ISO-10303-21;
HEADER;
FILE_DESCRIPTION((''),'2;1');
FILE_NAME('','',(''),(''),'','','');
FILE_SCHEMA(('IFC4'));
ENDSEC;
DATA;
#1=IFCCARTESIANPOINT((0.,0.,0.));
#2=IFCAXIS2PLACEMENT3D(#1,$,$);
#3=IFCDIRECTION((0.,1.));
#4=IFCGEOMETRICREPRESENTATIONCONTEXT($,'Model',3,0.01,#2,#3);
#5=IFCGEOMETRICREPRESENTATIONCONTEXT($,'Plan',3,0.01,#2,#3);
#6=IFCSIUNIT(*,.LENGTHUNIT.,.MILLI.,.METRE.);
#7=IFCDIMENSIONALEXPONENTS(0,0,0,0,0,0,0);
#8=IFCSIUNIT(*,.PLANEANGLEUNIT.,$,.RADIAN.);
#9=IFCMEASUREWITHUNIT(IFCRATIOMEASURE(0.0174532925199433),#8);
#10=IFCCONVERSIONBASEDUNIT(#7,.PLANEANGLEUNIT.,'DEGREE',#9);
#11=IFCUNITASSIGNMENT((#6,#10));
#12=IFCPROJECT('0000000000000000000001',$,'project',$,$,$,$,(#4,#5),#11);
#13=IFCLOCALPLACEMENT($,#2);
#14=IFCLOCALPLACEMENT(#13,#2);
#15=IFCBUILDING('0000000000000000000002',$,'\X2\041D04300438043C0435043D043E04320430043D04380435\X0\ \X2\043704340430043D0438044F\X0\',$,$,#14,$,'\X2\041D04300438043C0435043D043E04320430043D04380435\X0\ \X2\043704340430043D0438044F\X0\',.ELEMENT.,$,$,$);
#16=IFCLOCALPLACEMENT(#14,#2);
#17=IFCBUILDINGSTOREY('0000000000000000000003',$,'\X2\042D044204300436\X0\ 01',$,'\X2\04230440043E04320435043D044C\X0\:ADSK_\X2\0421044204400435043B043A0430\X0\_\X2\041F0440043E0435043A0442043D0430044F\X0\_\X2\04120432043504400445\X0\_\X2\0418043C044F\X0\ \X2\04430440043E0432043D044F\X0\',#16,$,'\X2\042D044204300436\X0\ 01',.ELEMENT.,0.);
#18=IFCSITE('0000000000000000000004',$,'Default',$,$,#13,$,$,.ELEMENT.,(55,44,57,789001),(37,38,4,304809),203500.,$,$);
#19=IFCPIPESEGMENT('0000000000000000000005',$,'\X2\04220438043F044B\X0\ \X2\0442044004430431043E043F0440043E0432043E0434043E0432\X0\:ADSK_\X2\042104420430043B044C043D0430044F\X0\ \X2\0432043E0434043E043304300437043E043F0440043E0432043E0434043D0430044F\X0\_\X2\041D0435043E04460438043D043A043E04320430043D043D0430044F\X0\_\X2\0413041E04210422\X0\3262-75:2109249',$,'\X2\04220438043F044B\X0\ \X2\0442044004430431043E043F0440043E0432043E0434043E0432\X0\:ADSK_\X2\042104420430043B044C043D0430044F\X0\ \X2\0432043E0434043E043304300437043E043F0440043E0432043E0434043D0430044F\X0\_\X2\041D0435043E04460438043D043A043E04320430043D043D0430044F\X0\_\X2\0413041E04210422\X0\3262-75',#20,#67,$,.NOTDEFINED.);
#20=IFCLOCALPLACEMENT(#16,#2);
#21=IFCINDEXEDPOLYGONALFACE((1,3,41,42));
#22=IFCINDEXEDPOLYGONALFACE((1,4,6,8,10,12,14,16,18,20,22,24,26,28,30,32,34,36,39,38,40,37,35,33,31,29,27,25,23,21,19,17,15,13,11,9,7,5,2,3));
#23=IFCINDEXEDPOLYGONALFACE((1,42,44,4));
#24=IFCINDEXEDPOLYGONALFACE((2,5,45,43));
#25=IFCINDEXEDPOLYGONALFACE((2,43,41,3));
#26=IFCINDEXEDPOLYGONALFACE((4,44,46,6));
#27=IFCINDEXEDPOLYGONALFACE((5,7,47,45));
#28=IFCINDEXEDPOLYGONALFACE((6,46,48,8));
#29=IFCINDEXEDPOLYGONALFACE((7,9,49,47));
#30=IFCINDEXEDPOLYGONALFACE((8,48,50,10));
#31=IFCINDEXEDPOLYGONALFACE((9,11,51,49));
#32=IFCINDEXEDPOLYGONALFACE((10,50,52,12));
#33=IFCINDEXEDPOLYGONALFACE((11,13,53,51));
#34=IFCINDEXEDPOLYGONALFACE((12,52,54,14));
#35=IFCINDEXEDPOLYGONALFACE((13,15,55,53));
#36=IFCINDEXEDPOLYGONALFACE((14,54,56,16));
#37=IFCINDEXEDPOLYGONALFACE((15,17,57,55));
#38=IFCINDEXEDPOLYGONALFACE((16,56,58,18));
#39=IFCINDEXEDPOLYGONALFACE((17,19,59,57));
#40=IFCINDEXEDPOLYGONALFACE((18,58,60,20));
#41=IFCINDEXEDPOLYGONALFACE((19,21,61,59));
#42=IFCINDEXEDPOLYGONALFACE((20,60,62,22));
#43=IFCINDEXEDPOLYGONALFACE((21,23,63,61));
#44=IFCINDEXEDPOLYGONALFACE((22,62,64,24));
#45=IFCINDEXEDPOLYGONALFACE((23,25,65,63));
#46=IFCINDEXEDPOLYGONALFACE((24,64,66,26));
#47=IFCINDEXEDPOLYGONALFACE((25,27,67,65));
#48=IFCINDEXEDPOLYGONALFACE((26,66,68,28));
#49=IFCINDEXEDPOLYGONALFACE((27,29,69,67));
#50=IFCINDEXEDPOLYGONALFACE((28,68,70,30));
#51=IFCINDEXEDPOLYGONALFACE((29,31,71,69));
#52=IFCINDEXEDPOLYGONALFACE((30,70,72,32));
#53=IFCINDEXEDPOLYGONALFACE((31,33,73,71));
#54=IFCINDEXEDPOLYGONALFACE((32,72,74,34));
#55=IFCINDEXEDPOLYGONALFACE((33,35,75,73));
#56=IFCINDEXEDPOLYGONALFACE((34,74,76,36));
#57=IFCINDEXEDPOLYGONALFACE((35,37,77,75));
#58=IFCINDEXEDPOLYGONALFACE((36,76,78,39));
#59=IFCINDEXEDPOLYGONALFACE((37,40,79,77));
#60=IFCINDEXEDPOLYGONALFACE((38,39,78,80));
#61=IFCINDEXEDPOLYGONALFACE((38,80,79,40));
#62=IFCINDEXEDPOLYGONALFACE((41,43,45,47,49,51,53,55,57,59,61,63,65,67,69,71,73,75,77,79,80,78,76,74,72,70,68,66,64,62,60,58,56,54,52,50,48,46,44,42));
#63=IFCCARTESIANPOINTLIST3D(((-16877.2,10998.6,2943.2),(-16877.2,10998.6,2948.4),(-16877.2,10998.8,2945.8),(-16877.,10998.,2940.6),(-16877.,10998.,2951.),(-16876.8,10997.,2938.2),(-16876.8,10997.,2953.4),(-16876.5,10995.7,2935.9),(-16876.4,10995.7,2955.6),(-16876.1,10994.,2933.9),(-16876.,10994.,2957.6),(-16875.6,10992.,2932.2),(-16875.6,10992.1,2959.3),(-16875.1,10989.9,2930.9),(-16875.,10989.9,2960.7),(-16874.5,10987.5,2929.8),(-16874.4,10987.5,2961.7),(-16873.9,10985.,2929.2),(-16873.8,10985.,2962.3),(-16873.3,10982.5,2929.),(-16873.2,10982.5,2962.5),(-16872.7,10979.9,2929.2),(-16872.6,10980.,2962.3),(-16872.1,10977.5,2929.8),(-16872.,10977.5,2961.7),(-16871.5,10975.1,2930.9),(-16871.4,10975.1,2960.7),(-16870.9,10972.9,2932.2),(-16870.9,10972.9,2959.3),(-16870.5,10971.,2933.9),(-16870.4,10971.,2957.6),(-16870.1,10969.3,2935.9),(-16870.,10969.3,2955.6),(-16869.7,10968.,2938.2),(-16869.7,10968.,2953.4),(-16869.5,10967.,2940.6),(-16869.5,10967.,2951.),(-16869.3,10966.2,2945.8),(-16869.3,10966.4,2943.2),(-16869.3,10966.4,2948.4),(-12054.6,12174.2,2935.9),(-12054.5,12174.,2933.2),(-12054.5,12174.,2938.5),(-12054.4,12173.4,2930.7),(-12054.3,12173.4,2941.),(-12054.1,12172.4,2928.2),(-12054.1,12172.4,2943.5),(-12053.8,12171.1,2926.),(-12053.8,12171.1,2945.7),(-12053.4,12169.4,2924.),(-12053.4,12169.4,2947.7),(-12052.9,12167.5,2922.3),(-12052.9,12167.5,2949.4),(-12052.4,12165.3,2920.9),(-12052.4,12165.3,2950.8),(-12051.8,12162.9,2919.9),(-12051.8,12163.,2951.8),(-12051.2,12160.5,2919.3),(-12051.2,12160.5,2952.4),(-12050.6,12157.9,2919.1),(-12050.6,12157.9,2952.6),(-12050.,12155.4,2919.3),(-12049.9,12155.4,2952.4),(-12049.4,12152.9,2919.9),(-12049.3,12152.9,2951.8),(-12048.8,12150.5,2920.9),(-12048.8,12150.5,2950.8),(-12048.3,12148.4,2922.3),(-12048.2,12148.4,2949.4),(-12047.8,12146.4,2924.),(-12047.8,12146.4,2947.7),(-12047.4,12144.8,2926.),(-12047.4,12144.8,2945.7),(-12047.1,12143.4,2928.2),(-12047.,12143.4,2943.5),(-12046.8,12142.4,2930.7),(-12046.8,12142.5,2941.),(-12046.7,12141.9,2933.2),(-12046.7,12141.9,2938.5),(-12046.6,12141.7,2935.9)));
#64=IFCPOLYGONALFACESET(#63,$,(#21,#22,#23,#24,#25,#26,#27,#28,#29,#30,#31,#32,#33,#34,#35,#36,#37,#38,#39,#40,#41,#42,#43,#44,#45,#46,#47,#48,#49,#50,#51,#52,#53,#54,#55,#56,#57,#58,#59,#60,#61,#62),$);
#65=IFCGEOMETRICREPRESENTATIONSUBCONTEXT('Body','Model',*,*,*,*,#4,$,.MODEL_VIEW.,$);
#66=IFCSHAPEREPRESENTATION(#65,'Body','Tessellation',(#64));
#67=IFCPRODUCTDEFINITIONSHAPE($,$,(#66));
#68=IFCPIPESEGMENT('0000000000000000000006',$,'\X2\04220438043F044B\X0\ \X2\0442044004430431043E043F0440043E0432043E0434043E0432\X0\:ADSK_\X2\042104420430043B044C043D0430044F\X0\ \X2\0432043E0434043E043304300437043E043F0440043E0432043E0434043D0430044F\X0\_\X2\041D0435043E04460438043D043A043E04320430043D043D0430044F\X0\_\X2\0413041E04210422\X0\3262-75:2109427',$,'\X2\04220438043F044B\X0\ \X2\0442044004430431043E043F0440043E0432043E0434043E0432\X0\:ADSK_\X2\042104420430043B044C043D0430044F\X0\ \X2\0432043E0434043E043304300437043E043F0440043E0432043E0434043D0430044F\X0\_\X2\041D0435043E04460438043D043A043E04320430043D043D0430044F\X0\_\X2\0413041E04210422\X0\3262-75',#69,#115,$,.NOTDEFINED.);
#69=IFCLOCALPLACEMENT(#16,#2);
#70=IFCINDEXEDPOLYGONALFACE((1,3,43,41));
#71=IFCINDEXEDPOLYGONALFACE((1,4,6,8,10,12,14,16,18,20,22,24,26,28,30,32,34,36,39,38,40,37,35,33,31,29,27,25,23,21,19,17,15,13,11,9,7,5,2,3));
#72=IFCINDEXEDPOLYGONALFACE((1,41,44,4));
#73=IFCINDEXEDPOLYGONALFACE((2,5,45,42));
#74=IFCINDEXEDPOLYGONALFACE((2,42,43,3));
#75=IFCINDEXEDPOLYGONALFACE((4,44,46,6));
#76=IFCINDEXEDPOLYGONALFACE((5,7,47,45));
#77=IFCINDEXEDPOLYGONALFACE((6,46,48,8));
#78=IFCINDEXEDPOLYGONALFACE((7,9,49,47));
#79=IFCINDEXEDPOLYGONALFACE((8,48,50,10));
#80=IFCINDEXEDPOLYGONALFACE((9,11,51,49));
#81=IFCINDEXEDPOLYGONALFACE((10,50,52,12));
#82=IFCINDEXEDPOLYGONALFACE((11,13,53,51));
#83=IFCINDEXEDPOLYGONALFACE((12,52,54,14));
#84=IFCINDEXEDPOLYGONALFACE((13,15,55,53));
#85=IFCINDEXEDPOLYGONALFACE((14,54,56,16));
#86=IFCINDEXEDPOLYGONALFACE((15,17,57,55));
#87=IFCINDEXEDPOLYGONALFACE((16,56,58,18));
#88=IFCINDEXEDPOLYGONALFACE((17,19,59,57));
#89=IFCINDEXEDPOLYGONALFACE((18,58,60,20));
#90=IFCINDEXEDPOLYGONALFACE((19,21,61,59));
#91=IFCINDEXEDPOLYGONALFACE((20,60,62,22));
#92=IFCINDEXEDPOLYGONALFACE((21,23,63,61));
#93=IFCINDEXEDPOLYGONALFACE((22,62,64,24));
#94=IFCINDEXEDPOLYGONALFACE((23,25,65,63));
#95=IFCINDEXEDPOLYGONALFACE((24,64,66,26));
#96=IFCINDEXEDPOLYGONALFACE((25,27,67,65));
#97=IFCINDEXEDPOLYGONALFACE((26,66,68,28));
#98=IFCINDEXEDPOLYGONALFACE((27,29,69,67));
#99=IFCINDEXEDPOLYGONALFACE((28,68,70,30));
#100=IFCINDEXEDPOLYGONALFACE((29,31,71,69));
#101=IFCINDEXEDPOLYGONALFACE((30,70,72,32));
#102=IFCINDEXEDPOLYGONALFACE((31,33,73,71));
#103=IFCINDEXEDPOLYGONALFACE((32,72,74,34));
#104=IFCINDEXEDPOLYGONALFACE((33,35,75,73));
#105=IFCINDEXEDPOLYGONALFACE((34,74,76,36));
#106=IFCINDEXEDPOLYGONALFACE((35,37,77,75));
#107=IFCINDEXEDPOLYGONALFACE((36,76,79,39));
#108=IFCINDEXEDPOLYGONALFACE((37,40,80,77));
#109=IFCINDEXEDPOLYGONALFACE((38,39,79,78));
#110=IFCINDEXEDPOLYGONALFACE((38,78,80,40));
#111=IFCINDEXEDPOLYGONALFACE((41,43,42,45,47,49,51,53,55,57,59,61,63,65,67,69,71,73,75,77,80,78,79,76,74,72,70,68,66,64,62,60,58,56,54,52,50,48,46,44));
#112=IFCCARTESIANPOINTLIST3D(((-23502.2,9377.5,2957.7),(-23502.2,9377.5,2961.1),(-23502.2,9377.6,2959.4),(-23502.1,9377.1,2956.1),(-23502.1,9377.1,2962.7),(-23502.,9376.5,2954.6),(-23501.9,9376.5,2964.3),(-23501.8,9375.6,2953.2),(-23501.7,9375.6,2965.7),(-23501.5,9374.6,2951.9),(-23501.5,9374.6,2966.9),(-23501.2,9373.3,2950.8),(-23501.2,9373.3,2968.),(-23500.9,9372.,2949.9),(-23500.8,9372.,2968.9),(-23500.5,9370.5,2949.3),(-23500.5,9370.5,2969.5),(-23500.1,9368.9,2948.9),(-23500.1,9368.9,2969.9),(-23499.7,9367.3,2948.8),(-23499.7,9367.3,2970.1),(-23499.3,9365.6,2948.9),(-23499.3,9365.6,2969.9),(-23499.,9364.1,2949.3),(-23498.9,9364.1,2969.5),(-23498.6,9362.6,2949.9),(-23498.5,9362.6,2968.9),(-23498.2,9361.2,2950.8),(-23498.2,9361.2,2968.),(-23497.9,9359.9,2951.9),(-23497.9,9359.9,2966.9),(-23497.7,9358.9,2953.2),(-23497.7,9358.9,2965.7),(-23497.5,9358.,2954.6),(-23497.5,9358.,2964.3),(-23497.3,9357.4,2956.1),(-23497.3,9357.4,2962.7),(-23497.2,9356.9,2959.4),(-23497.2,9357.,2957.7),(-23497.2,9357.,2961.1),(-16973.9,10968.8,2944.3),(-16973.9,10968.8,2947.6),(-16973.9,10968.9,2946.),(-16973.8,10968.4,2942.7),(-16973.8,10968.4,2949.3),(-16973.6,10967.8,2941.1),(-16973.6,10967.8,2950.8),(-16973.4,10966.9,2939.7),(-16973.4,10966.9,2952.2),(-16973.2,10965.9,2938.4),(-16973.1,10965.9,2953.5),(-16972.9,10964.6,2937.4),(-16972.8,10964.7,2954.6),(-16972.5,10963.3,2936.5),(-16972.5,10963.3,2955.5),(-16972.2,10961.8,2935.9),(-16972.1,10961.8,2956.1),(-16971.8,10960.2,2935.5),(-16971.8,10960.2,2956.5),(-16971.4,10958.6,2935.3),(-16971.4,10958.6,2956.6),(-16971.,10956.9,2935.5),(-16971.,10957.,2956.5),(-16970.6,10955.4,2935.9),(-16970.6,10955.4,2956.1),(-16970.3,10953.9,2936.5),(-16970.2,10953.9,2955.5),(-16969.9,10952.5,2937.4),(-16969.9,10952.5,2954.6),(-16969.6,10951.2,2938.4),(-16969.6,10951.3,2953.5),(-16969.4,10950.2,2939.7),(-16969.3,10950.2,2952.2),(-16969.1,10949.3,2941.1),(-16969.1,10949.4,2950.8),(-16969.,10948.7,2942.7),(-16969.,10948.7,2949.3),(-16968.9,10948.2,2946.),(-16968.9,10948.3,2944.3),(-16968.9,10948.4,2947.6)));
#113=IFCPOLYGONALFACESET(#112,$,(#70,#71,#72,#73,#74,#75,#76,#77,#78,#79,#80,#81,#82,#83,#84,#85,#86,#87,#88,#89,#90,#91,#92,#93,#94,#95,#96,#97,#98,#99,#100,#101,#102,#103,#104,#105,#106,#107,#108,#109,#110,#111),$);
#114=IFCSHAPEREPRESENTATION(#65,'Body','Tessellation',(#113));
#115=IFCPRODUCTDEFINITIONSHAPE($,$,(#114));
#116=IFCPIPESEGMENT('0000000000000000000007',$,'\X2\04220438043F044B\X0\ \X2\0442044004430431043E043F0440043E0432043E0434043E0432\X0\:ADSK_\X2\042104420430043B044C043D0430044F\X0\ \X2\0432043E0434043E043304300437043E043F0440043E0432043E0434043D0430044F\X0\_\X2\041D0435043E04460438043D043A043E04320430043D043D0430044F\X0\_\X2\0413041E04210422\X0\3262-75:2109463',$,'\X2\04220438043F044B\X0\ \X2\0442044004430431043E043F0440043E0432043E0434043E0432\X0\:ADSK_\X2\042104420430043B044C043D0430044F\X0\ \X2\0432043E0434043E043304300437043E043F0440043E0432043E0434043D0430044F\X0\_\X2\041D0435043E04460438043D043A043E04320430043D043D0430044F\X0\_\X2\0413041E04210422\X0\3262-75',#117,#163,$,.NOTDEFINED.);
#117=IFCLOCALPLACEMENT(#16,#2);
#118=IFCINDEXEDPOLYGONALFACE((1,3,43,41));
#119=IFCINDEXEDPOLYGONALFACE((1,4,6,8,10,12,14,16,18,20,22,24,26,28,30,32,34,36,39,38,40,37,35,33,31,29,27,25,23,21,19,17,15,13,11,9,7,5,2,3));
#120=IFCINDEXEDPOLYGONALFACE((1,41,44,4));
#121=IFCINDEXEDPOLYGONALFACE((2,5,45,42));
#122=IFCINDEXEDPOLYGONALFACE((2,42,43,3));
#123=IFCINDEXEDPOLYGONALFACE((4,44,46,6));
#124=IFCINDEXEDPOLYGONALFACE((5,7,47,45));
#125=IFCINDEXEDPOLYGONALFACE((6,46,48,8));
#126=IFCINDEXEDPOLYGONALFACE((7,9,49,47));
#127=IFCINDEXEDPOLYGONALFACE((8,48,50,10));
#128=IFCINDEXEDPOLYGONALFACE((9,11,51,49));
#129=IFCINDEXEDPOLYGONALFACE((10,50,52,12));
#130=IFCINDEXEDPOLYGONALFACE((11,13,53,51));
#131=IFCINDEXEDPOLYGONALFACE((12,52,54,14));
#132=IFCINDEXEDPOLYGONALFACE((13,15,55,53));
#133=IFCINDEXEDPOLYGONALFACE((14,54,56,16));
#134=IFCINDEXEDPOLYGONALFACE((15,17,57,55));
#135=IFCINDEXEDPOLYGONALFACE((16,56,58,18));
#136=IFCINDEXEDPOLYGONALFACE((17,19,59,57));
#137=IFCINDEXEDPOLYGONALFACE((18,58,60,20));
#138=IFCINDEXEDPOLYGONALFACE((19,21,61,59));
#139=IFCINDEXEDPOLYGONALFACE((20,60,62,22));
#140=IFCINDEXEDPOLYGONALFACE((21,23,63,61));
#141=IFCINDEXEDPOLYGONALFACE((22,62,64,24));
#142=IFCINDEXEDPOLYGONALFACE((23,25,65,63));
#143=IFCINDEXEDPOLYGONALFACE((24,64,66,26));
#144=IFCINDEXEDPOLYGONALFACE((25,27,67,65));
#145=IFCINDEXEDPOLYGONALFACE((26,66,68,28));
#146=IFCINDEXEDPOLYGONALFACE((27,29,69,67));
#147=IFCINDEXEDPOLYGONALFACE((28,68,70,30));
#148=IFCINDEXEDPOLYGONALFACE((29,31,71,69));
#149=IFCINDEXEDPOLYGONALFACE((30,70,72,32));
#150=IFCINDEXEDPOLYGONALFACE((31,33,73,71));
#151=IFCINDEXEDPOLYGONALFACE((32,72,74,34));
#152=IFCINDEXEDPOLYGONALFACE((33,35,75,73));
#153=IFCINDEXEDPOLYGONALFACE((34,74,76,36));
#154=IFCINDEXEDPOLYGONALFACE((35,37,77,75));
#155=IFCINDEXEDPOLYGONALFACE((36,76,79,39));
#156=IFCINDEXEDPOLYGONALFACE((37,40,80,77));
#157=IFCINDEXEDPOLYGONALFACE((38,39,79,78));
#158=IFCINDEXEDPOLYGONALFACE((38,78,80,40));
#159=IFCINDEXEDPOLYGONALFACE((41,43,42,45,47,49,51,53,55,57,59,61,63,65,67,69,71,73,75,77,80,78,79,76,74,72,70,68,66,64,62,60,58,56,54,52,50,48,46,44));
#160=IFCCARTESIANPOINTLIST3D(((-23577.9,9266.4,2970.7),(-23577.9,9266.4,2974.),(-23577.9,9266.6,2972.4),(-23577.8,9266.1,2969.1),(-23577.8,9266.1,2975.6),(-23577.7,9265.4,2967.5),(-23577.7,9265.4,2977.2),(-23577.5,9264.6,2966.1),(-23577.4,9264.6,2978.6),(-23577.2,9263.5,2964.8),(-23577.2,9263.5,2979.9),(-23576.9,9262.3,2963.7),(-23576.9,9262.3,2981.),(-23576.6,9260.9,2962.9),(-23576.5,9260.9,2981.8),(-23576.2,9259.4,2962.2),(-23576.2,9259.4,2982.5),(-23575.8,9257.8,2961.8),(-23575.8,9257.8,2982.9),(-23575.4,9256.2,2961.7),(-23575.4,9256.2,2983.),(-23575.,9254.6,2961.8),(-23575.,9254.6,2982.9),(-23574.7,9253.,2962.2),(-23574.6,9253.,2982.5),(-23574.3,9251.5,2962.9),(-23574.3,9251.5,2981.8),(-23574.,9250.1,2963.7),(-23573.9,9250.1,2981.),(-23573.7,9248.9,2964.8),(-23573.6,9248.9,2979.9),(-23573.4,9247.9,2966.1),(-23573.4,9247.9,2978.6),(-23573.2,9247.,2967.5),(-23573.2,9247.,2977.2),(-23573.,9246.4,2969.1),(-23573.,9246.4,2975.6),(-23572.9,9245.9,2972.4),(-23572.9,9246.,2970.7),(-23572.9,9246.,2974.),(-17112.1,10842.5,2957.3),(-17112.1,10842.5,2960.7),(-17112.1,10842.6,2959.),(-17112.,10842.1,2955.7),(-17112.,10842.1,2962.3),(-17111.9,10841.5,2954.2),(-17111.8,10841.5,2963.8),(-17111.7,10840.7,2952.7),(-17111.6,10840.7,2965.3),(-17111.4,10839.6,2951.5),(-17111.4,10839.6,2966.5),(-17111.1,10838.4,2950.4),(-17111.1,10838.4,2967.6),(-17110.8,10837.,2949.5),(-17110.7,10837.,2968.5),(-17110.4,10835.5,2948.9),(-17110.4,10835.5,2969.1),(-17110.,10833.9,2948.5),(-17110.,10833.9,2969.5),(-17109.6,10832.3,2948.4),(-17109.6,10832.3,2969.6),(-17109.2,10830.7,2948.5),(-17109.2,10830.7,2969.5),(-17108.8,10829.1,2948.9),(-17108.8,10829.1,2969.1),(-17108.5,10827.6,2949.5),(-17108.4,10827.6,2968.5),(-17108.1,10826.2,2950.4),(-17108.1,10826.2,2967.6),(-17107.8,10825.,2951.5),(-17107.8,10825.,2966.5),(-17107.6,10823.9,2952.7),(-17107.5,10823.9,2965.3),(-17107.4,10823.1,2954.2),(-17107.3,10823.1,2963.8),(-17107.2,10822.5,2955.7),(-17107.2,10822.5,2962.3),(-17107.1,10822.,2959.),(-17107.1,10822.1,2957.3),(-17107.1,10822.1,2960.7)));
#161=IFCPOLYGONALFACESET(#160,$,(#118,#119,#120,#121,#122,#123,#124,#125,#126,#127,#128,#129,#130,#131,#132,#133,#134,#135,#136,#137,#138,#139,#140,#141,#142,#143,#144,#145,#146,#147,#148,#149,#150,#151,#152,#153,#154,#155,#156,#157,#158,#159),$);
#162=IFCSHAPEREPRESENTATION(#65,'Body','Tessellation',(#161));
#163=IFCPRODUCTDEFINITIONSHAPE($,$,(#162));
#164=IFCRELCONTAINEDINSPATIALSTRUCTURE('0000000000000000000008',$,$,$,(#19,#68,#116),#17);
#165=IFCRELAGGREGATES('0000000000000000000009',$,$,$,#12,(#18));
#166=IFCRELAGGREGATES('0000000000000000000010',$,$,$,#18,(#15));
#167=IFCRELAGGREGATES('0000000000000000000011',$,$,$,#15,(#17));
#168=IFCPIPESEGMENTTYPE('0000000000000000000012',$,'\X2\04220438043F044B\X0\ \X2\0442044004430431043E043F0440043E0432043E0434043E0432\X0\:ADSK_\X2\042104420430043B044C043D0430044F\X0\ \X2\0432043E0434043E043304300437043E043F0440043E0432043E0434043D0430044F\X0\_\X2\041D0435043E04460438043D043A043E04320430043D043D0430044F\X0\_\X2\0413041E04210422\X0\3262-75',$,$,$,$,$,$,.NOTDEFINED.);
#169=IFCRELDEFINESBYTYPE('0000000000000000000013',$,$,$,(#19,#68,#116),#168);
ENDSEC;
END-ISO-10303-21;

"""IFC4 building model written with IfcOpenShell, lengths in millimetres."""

from ifc_helpers import new_model, entity, si_unit, converted_unit, direction, frame, origin, place, context, subcontext, project, spatial, indexed_curve, outline, extrude, type_object, element, save


model = new_model("IFC4")

# Units and contexts
model_context = context("Model", 3, precision=0.01, world=origin(), true_north=direction((0.0, 1.0)))
plan_context = context("Plan", 3, precision=0.01, world=origin(), true_north=direction((0.0, 1.0)))
body_context = subcontext(model_context, "Body", "Model", "MODEL_VIEW")
ifc_project = project(units=[si_unit("LENGTHUNIT", "METRE", prefix="MILLI"), converted_unit("PLANEANGLEUNIT", "DEGREE", entity("IfcRatioMeasure", 0.0174532925199433), si_unit("PLANEANGLEUNIT", "RADIAN"), dimensions=[0, 0, 0, 0, 0, 0, 0])], contexts=[model_context, plan_context])

# Site, building, storey
site_placement = place(None, origin())
site = spatial("IfcSite", under=ifc_project, at=site_placement, Name="Default", CompositionType="ELEMENT", RefLatitude=(55, 44, 57, 789001), RefLongitude=(37, 38, 4, 304809), RefElevation=203500.0)
building_placement = place(site_placement, origin())
building = spatial("IfcBuilding", under=site, at=building_placement, Name="Наименование здания", LongName="Наименование здания", CompositionType="ELEMENT")
storey_placement = place(building_placement, origin())
storey = spatial("IfcBuildingStorey", under=building, at=storey_placement, Name="Этаж 01", ObjectType="Уровень:ADSK_Стрелка_Проектная_Вверх_Имя уровня", LongName="Этаж 01", CompositionType="ELEMENT", Elevation=0.0)

# Pipe segments
pipe_segment_type = type_object("IfcPipeSegmentType", Name="Типы трубопроводов:ADSK_Стальная водогазопроводная_Неоцинкованная_ГОСТ3262-75", PredefinedType="NOTDEFINED")
placement = place(storey_placement, origin())
element("IfcPipeSegment", 1, at=placement, inside=storey, type_object=pipe_segment_type, Name="Типы трубопроводов:ADSK_Стальная водогазопроводная_Неоцинкованная_ГОСТ3262-75:2109249", ObjectType="Типы трубопроводов:ADSK_Стальная водогазопроводная_Неоцинкованная_ГОСТ3262-75", PredefinedType="NOTDEFINED", context=body_context, shape_type="SweptSolid", body=[
    extrude(outline(indexed_curve([(16.7, 0.0), (16.5, 2.6), (15.9, 5.2), (14.9, 7.6), (13.6, 9.8), (11.8, 11.8), (9.8, 13.6), (7.6, 14.9), (5.2, 15.9), (2.6, 16.5), (0.0, 16.7), (-2.6, 16.5), (-5.2, 15.9), (-7.6, 14.9), (-9.8, 13.6), (-11.8, 11.8), (-13.6, 9.8), (-14.9, 7.6), (-15.9, 5.2), (-16.5, 2.6), (-16.7, 0.0), (-16.5, -2.6), (-15.9, -5.2), (-14.9, -7.6), (-13.6, -9.8), (-11.8, -11.8), (-9.8, -13.6), (-7.6, -14.9), (-5.2, -15.9), (-2.6, -16.5), (0.0, -16.7), (2.6, -16.5), (5.2, -15.9), (7.6, -14.9), (9.8, -13.6), (11.8, -11.8), (13.6, -9.8), (14.9, -7.6), (15.9, -5.2), (16.5, -2.6), (16.7, 0.0)], self_intersect=False)), frame((-16873.2, 10982.5, 2945.8), z_axis=(0.971557, 0.236799, -0.002), x_axis=(0.236799, -0.971559, 0.0)), (0.0, 0.0, 1.0), 4963.9),
])
element("IfcPipeSegment", 2, at=placement, inside=storey, type_object=pipe_segment_type, Name="Типы трубопроводов:ADSK_Стальная водогазопроводная_Неоцинкованная_ГОСТ3262-75:2109427", ObjectType="Типы трубопроводов:ADSK_Стальная водогазопроводная_Неоцинкованная_ГОСТ3262-75", PredefinedType="NOTDEFINED", context=body_context, shape_type="SweptSolid", body=[
    extrude(outline(indexed_curve([(10.7, 0.0), (10.5, 1.7), (10.1, 3.3), (9.5, 4.8), (8.6, 6.3), (7.5, 7.5), (6.3, 8.6), (4.8, 9.5), (3.3, 10.1), (1.7, 10.5), (0.0, 10.7), (-1.7, 10.5), (-3.3, 10.1), (-4.8, 9.5), (-6.3, 8.6), (-7.5, 7.5), (-8.6, 6.3), (-9.5, 4.8), (-10.1, 3.3), (-10.5, 1.7), (-10.6, 0.0), (-10.5, -1.7), (-10.1, -3.3), (-9.5, -4.8), (-8.6, -6.3), (-7.5, -7.5), (-6.3, -8.6), (-4.8, -9.5), (-3.3, -10.1), (-1.7, -10.5), (0.0, -10.7), (1.7, -10.5), (3.3, -10.1), (4.8, -9.5), (6.3, -8.6), (7.5, -7.5), (8.6, -6.3), (9.5, -4.8), (10.1, -3.3), (10.5, -1.7), (10.7, 0.0)], self_intersect=False)), frame((-16971.4, 10958.6, 2946.0), z_axis=(-0.971551, -0.23682, 0.001999), x_axis=(0.236821, -0.971553, 0.0)), (0.0, 0.0, 1.0), 6719.5),
])
element("IfcPipeSegment", 3, at=placement, inside=storey, type_object=pipe_segment_type, Name="Типы трубопроводов:ADSK_Стальная водогазопроводная_Неоцинкованная_ГОСТ3262-75:2109463", ObjectType="Типы трубопроводов:ADSK_Стальная водогазопроводная_Неоцинкованная_ГОСТ3262-75", PredefinedType="NOTDEFINED", context=body_context, shape_type="SweptSolid", body=[
    extrude(outline(indexed_curve([(10.6, 0.0), (10.5, 1.7), (10.1, 3.3), (9.5, 4.8), (8.6, 6.3), (7.5, 7.5), (6.3, 8.6), (4.8, 9.5), (3.3, 10.1), (1.7, 10.5), (0.0, 10.7), (-1.7, 10.5), (-3.3, 10.1), (-4.8, 9.5), (-6.3, 8.6), (-7.5, 7.5), (-8.6, 6.3), (-9.5, 4.8), (-10.1, 3.3), (-10.5, 1.7), (-10.6, 0.0), (-10.5, -1.7), (-10.1, -3.3), (-9.5, -4.8), (-8.6, -6.3), (-7.5, -7.5), (-6.3, -8.6), (-4.8, -9.5), (-3.3, -10.1), (-1.7, -10.5), (0.0, -10.7), (1.7, -10.5), (3.3, -10.1), (4.8, -9.5), (6.3, -8.6), (7.5, -7.5), (8.6, -6.3), (9.5, -4.8), (10.1, -3.3), (10.5, -1.7), (10.6, 0.0)], self_intersect=False)), frame((-17109.6, 10832.3, 2959.0), z_axis=(-0.971551, -0.23682, 0.002006), x_axis=(0.236821, -0.971553, 0.0)), (0.0, 0.0, 1.0), 6655.1),
])

save(model, "model.ifc")
